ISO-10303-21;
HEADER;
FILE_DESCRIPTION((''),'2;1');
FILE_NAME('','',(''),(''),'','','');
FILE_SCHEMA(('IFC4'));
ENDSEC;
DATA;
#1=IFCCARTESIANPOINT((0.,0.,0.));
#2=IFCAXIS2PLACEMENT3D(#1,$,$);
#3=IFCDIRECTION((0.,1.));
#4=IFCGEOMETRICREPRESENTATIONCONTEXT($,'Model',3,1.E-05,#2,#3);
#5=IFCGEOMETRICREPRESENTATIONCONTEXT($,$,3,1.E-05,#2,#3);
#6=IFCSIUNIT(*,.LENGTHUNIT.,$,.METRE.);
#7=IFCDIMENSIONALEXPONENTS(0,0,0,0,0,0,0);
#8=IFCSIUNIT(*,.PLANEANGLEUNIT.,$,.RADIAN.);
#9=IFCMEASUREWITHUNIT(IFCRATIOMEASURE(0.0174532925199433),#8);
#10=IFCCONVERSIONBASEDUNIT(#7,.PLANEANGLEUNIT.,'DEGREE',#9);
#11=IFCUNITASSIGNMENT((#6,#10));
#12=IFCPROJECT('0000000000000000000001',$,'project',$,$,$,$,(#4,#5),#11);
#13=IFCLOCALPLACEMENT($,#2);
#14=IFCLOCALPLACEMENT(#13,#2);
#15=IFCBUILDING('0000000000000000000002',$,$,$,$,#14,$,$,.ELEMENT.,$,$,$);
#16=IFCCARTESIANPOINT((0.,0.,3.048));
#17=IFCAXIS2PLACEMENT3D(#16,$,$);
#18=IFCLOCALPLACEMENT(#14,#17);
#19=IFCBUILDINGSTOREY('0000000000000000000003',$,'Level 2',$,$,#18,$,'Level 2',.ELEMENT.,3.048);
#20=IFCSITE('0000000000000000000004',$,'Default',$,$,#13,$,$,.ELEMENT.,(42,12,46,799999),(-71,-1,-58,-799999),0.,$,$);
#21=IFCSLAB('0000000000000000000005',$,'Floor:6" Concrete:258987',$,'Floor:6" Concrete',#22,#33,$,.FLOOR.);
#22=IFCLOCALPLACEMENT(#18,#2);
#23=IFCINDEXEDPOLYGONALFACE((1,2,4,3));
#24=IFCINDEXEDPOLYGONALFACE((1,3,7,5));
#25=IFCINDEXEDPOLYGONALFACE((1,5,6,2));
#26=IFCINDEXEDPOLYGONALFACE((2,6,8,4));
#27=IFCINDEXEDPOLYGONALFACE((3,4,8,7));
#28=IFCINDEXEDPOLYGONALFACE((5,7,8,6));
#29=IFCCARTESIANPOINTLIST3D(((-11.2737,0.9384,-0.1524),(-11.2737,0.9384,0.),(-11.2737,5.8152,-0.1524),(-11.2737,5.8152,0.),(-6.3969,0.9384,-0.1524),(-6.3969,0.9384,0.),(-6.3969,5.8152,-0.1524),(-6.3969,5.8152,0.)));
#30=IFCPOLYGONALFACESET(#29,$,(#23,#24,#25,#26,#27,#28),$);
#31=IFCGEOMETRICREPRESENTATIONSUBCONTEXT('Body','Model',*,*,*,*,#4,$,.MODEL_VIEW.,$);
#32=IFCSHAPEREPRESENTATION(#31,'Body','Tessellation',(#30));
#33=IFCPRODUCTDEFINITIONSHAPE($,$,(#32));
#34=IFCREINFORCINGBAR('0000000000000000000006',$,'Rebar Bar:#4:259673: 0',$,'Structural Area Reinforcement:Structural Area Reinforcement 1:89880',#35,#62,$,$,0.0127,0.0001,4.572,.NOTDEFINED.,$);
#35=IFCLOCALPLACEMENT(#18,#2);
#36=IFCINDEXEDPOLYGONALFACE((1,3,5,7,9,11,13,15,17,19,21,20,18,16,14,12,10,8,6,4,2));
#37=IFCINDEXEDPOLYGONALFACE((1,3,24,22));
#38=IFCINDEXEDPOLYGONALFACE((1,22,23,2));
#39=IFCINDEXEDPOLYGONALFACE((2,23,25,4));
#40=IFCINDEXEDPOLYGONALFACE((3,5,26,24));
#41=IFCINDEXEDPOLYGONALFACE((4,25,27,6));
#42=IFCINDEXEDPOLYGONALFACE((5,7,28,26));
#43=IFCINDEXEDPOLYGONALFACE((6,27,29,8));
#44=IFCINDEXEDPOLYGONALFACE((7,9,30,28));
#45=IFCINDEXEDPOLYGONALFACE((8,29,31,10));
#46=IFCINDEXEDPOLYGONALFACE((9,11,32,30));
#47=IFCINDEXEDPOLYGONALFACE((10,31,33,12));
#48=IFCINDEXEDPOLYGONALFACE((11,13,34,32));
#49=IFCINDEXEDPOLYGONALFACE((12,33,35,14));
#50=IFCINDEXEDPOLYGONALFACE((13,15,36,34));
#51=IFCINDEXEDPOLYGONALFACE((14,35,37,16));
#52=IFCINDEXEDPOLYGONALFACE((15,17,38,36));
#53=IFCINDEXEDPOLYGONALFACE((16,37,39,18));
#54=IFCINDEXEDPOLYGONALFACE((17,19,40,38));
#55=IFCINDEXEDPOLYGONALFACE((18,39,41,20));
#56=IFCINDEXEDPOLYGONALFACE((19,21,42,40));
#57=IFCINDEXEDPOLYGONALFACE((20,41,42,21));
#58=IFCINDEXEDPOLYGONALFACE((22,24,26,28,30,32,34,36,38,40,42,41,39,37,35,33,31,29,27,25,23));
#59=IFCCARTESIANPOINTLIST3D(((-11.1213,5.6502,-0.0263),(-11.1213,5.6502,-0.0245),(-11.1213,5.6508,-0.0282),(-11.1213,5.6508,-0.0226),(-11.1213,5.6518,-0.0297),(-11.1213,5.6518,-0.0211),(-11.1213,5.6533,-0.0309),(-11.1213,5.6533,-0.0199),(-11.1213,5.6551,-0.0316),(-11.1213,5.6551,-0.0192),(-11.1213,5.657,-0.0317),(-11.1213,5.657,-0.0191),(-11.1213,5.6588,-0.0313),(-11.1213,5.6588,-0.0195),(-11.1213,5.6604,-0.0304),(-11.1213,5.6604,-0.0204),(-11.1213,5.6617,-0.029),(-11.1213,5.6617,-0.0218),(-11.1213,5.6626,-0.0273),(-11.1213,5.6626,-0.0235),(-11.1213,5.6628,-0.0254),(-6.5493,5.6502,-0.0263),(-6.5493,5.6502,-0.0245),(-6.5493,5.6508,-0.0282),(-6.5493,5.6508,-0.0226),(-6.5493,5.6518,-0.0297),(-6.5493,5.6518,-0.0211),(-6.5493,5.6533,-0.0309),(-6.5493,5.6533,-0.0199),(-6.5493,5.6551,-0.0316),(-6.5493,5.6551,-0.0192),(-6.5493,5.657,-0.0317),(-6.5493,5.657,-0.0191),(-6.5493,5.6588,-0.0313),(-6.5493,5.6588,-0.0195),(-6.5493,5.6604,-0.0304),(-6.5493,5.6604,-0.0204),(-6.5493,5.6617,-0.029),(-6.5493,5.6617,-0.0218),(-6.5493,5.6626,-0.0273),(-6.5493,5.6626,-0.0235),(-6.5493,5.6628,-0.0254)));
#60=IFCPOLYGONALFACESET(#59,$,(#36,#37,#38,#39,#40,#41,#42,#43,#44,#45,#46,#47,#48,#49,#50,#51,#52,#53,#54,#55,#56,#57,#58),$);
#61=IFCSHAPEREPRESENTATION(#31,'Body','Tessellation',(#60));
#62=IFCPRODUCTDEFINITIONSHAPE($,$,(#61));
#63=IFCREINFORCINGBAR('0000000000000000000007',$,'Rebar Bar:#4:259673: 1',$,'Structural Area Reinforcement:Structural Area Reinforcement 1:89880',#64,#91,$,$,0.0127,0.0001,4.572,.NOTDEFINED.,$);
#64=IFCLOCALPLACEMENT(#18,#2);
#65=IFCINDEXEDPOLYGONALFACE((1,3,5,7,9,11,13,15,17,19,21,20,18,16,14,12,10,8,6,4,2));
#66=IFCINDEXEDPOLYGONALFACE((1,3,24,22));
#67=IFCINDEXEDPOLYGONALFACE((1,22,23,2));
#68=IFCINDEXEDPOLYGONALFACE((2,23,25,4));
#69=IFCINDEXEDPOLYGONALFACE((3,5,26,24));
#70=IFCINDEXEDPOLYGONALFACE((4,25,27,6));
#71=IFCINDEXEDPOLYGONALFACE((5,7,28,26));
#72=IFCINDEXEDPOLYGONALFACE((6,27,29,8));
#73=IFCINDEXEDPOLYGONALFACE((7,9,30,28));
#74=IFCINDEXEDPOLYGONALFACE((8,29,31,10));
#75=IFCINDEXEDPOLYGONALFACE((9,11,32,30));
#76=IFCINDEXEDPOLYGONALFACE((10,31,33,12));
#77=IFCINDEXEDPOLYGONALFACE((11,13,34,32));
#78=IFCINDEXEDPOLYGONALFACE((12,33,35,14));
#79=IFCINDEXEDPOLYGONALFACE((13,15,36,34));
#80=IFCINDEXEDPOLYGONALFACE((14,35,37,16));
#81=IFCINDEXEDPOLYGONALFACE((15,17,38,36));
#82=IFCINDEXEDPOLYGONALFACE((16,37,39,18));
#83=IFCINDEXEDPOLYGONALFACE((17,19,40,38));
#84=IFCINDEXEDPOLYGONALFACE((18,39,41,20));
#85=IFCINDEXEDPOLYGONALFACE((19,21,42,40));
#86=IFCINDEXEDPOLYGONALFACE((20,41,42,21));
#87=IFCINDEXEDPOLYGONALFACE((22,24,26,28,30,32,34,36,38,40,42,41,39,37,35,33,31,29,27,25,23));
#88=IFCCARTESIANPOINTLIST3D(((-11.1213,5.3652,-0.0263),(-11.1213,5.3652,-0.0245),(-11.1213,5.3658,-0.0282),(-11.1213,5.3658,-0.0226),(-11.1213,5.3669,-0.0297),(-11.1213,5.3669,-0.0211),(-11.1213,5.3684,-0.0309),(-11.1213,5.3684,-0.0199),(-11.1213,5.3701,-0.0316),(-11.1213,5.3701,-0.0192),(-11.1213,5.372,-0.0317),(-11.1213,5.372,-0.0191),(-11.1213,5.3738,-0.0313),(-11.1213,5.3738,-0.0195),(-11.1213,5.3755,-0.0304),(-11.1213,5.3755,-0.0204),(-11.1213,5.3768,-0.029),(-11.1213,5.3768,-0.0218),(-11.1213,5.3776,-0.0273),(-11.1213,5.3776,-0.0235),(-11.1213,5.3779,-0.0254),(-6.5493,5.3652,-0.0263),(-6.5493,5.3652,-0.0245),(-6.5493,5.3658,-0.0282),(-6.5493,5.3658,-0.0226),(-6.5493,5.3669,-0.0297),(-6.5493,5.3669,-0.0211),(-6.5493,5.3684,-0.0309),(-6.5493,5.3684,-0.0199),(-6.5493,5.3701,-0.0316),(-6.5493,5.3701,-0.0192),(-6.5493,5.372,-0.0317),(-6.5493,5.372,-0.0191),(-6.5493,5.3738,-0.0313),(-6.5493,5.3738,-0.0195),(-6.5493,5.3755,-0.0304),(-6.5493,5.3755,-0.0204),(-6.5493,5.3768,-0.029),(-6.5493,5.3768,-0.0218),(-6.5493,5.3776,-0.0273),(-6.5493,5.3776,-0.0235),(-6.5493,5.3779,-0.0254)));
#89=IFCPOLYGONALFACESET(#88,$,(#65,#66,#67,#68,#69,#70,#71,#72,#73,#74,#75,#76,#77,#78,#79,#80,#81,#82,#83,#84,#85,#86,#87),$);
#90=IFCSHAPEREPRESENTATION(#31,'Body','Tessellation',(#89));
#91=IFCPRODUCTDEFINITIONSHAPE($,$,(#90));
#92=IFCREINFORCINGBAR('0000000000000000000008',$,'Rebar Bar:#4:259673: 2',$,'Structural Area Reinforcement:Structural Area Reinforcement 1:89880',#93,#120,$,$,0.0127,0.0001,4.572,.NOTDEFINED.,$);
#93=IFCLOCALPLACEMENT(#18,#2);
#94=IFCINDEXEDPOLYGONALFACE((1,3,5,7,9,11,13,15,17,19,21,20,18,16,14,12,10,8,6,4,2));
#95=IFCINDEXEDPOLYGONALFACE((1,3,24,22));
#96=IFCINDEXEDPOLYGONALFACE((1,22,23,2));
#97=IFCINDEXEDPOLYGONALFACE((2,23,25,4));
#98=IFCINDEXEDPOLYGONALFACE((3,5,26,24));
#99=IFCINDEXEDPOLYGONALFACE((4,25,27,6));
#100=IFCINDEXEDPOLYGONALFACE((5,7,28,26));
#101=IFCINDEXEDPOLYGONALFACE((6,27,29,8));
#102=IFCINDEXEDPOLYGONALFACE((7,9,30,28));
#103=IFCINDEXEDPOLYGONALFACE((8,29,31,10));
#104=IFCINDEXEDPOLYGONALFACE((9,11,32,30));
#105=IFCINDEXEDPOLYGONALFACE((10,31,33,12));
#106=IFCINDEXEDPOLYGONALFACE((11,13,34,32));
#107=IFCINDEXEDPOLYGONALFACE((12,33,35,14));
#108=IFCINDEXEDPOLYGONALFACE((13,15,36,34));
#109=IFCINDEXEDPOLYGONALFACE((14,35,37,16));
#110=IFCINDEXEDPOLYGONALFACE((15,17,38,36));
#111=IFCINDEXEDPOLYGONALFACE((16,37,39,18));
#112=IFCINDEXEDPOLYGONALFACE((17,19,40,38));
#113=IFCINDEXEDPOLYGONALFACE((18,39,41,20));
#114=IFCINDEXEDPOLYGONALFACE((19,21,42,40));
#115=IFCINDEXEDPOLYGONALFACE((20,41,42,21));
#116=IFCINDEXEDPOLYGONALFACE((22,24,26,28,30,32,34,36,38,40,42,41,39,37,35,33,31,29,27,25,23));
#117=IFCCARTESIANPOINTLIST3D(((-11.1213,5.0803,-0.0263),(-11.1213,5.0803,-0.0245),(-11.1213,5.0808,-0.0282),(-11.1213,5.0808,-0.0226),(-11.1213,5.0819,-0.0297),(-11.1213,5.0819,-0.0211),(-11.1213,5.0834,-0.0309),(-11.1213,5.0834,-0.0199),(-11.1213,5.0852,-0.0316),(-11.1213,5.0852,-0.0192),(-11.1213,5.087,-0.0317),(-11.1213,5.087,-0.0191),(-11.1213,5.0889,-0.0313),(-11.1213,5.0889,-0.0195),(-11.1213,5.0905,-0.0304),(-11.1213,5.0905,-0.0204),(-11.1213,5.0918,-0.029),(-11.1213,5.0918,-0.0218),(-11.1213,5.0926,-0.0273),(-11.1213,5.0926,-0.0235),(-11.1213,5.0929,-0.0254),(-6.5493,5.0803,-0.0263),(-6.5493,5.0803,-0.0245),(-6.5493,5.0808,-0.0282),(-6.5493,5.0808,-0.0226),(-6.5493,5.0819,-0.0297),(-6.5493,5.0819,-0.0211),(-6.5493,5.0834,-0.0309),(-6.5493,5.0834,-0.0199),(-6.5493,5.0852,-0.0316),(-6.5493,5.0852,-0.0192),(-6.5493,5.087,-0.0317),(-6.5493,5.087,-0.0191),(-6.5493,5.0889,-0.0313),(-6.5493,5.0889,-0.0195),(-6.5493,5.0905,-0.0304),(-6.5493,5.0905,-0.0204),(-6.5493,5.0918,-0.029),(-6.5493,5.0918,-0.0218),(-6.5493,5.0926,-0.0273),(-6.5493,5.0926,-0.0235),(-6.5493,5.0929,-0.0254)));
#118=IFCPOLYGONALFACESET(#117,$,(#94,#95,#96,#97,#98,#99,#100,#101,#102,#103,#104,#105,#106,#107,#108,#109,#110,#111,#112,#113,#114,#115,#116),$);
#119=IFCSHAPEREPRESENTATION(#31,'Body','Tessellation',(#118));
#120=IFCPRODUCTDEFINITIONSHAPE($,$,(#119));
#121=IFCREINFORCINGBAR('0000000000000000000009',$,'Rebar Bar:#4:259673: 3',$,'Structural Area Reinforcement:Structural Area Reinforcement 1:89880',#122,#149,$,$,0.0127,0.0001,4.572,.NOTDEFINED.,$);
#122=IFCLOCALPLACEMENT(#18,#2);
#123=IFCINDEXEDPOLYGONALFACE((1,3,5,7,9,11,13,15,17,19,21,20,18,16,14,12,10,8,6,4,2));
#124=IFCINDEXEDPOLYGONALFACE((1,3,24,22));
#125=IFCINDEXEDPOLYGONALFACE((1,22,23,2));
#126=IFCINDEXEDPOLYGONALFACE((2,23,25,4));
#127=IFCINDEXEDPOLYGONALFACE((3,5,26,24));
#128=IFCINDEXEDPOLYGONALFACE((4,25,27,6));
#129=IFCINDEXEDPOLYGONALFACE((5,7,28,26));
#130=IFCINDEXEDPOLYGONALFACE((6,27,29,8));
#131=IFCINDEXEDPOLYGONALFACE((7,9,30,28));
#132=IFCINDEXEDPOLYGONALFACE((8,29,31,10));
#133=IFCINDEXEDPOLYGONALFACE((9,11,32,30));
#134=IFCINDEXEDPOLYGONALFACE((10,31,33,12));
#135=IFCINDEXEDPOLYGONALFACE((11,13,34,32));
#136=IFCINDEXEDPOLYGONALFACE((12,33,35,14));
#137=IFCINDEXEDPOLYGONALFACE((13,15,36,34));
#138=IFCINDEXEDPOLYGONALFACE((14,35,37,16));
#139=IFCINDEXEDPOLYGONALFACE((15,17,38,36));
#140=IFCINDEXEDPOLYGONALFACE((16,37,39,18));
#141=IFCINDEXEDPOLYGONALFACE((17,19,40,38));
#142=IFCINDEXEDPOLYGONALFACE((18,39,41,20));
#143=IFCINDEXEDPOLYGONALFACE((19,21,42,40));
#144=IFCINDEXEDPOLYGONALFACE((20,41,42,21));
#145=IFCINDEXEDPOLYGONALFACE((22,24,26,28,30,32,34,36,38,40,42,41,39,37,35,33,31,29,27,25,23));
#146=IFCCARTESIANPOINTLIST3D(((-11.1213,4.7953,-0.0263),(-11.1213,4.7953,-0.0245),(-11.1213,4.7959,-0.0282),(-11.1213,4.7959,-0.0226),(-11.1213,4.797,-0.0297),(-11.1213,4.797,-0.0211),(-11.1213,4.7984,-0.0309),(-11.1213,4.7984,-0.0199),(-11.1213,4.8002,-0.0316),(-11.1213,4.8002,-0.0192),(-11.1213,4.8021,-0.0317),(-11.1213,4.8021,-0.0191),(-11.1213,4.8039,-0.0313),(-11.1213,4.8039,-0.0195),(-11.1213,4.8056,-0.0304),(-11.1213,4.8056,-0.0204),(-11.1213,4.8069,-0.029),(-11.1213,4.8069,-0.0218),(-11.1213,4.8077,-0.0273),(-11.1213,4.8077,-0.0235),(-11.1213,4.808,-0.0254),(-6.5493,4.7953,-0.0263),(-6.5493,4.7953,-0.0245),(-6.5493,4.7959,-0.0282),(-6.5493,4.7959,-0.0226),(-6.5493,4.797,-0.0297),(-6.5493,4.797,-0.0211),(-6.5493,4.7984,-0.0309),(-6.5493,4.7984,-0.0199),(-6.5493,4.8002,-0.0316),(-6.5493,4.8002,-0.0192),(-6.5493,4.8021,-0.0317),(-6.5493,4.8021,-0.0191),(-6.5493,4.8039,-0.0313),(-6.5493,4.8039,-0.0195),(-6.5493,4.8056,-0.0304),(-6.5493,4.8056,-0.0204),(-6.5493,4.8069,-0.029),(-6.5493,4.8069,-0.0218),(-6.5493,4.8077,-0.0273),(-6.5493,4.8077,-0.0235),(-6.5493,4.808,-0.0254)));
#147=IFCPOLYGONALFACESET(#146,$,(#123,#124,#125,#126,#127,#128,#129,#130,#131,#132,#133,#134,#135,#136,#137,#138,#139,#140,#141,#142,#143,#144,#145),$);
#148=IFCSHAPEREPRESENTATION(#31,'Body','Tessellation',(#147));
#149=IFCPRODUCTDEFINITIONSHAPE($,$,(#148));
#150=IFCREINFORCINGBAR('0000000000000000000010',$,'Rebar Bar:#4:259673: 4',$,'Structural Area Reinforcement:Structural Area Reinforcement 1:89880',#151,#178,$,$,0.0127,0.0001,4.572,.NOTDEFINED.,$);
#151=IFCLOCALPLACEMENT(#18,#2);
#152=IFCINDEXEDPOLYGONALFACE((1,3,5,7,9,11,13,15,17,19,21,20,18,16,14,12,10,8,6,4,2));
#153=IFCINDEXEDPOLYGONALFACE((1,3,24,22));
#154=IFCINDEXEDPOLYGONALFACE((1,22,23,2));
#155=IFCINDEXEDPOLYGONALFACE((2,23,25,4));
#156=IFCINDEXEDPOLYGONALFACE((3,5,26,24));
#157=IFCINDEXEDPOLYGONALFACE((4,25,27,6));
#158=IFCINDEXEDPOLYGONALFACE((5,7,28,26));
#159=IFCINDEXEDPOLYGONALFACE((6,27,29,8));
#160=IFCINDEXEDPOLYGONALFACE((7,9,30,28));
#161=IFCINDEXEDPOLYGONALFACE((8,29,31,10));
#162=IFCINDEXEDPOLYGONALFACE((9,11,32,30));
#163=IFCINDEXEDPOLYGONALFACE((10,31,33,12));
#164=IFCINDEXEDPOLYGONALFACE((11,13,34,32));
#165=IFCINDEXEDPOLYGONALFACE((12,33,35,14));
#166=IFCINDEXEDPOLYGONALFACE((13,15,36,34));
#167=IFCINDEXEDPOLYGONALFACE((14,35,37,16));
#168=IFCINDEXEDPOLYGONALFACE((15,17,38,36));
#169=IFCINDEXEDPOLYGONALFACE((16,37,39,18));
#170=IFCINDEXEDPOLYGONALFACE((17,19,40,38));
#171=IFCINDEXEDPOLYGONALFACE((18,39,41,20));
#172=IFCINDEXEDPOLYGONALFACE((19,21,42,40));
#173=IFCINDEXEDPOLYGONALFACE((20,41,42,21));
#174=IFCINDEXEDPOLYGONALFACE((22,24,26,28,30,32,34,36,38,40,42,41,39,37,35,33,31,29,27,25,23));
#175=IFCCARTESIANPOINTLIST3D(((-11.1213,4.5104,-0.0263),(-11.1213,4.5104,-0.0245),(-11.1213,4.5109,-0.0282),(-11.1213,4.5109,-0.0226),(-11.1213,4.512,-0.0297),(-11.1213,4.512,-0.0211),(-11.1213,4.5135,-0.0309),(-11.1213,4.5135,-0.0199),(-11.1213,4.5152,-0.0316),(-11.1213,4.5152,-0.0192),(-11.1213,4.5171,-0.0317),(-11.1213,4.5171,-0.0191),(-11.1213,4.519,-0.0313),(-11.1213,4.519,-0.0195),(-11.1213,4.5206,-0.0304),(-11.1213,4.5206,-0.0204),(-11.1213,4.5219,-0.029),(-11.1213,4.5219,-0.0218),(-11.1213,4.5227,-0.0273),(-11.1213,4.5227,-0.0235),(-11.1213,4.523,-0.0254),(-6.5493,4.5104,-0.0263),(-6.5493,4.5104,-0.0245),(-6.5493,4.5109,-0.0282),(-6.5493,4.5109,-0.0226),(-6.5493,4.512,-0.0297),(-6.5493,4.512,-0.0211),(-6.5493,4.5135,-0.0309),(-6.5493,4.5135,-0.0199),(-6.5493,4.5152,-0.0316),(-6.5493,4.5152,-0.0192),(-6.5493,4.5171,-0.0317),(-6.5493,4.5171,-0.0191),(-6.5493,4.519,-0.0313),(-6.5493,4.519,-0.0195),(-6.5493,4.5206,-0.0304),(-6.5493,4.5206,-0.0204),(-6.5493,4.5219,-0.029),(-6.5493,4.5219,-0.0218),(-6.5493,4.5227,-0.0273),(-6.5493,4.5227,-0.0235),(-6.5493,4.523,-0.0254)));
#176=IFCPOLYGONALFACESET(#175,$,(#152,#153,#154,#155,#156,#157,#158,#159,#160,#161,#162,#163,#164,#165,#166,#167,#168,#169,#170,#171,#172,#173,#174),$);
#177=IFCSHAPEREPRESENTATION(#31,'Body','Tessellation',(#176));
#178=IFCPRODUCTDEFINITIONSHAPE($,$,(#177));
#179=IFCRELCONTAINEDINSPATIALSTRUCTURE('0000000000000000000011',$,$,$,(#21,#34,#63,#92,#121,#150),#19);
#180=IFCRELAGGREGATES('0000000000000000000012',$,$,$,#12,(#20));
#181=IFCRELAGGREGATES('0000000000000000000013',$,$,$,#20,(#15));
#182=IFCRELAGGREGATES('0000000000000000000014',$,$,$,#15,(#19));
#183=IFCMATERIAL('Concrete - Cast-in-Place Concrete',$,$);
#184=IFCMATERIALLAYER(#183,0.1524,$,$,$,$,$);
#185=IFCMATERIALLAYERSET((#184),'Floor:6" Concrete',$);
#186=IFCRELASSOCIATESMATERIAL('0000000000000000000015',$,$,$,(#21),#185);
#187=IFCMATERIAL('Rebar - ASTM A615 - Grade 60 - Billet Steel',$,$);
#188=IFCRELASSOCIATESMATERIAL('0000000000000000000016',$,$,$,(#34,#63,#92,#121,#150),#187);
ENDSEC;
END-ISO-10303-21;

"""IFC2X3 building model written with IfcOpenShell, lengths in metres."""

from ifc_helpers import new_model, entity, si_unit, converted_unit, direction, frame, frame_2d, origin, place, context, subcontext, project, spatial, rectangle, extrude, material, layer, layer_set, layer_usage, element, save


model = new_model("IFC2X3")

# Units and contexts
model_context = context("Model", 3, precision=1e-05, world=origin(), true_north=direction((0.0, 1.0)))
context_of_model = context(None, 3, precision=1e-05, world=origin(), true_north=direction((0.0, 1.0)))
body_context = subcontext(model_context, "Body", "Model", "MODEL_VIEW")
ifc_project = project(units=[si_unit("LENGTHUNIT", "METRE"), converted_unit("PLANEANGLEUNIT", "DEGREE", entity("IfcRatioMeasure", 0.0174532925199433), si_unit("PLANEANGLEUNIT", "RADIAN"), dimensions=[0, 0, 0, 0, 0, 0, 0])], contexts=[model_context, context_of_model])

# Site, building, storey
site_placement = place(None, origin())
site = spatial("IfcSite", under=ifc_project, at=site_placement, Name="Default", CompositionType="ELEMENT", RefLatitude=(42, 12, 46, 799999), RefLongitude=(-71, -1, -58, -799999), RefElevation=0.0)
building_placement = place(site_placement, origin())
building = spatial("IfcBuilding", under=site, at=building_placement, CompositionType="ELEMENT")
storey_placement = place(building_placement, frame((0.0, 0.0, 3.048)))
storey = spatial("IfcBuildingStorey", under=building, at=storey_placement, Name="Level 2", LongName="Level 2", CompositionType="ELEMENT", Elevation=3.048)

# Shared definitions
ifc_material_1 = material(Name="Concrete - Cast-in-Place Concrete")

# Slab
ifc_layer = layer(ifc_material_1, 0.1524)
ifc_layer_set = layer_set([ifc_layer], Name="Floor:6\" Concrete")
ifc_layer_usage = layer_usage(ifc_layer_set, "AXIS3", "POSITIVE", 0.0)
slab_placement = place(storey_placement, origin())
element("IfcSlab", 1, at=slab_placement, inside=storey, material=ifc_layer_usage, Name="Floor:6\" Concrete:258987", ObjectType="Floor:6\" Concrete", PredefinedType="FLOOR", context=body_context, shape_type="SweptSolid", body=[
    extrude(rectangle(XDim=4.8768, YDim=4.8768, at=frame_2d((0.0, 0.0), x_axis=(1.0, 0.0))), frame((-8.8353, 3.3768, 0.0), z_axis=(0.0, 0.0, -1.0), x_axis=(0.0, 1.0, 0.0)), (0.0, 0.0, 1.0), 0.1524),
])

# Reinforcing bars
ifc_material_2 = material(Name="Rebar - ASTM A615 - Grade 60 - Billet Steel")
reinforcing_bar_1_placement = place(storey_placement, origin())
element("IfcReinforcingBar", 2, at=reinforcing_bar_1_placement, inside=storey, material=ifc_material_2, Name="Rebar Bar:#4:259673: 0", ObjectType="Structural Area Reinforcement:Structural Area Reinforcement 1:89880", BarLength=4.572, BarRole="NOTDEFINED", CrossSectionArea=0.0001, NominalDiameter=0.0127, context=body_context, shape_type="AdvancedSweptSolid", body=[
    entity("IfcSweptDiskSolid", entity("IfcCompositeCurve", [entity("IfcCompositeCurveSegment", "CONTINUOUS", True, entity("IfcPolyline", [entity("IfcCartesianPoint", [-11.1213, 5.6565, -0.0254]), entity("IfcCartesianPoint", [-6.5493, 5.6565, -0.0254])]))], False), 0.0063, None, 0.0, 1.0),
])
reinforcing_bar_2_placement = place(storey_placement, origin())
element("IfcReinforcingBar", 3, at=reinforcing_bar_2_placement, inside=storey, material=ifc_material_2, Name="Rebar Bar:#4:259673: 1", ObjectType="Structural Area Reinforcement:Structural Area Reinforcement 1:89880", BarLength=4.572, BarRole="NOTDEFINED", CrossSectionArea=0.0001, NominalDiameter=0.0127, context=body_context, shape_type="AdvancedSweptSolid", body=[
    entity("IfcSweptDiskSolid", entity("IfcCompositeCurve", [entity("IfcCompositeCurveSegment", "CONTINUOUS", True, entity("IfcPolyline", [entity("IfcCartesianPoint", [-11.1213, 5.3715, -0.0254]), entity("IfcCartesianPoint", [-6.5493, 5.3715, -0.0254])]))], False), 0.0063, None, 0.0, 1.0),
])
reinforcing_bar_3_placement = place(storey_placement, origin())
element("IfcReinforcingBar", 4, at=reinforcing_bar_3_placement, inside=storey, material=ifc_material_2, Name="Rebar Bar:#4:259673: 2", ObjectType="Structural Area Reinforcement:Structural Area Reinforcement 1:89880", BarLength=4.572, BarRole="NOTDEFINED", CrossSectionArea=0.0001, NominalDiameter=0.0127, context=body_context, shape_type="AdvancedSweptSolid", body=[
    entity("IfcSweptDiskSolid", entity("IfcCompositeCurve", [entity("IfcCompositeCurveSegment", "CONTINUOUS", True, entity("IfcPolyline", [entity("IfcCartesianPoint", [-11.1213, 5.0866, -0.0254]), entity("IfcCartesianPoint", [-6.5493, 5.0866, -0.0254])]))], False), 0.0063, None, 0.0, 1.0),
])
reinforcing_bar_4_placement = place(storey_placement, origin())
element("IfcReinforcingBar", 5, at=reinforcing_bar_4_placement, inside=storey, material=ifc_material_2, Name="Rebar Bar:#4:259673: 3", ObjectType="Structural Area Reinforcement:Structural Area Reinforcement 1:89880", BarLength=4.572, BarRole="NOTDEFINED", CrossSectionArea=0.0001, NominalDiameter=0.0127, context=body_context, shape_type="AdvancedSweptSolid", body=[
    entity("IfcSweptDiskSolid", entity("IfcCompositeCurve", [entity("IfcCompositeCurveSegment", "CONTINUOUS", True, entity("IfcPolyline", [entity("IfcCartesianPoint", [-11.1213, 4.8016, -0.0254]), entity("IfcCartesianPoint", [-6.5493, 4.8016, -0.0254])]))], False), 0.0063, None, 0.0, 1.0),
])
reinforcing_bar_5_placement = place(storey_placement, origin())
element("IfcReinforcingBar", 6, at=reinforcing_bar_5_placement, inside=storey, material=ifc_material_2, Name="Rebar Bar:#4:259673: 4", ObjectType="Structural Area Reinforcement:Structural Area Reinforcement 1:89880", BarLength=4.572, BarRole="NOTDEFINED", CrossSectionArea=0.0001, NominalDiameter=0.0127, context=body_context, shape_type="AdvancedSweptSolid", body=[
    entity("IfcSweptDiskSolid", entity("IfcCompositeCurve", [entity("IfcCompositeCurveSegment", "CONTINUOUS", True, entity("IfcPolyline", [entity("IfcCartesianPoint", [-11.1213, 4.5167, -0.0254]), entity("IfcCartesianPoint", [-6.5493, 4.5167, -0.0254])]))], False), 0.0063, None, 0.0, 1.0),
])

save(model, "model.ifc")
